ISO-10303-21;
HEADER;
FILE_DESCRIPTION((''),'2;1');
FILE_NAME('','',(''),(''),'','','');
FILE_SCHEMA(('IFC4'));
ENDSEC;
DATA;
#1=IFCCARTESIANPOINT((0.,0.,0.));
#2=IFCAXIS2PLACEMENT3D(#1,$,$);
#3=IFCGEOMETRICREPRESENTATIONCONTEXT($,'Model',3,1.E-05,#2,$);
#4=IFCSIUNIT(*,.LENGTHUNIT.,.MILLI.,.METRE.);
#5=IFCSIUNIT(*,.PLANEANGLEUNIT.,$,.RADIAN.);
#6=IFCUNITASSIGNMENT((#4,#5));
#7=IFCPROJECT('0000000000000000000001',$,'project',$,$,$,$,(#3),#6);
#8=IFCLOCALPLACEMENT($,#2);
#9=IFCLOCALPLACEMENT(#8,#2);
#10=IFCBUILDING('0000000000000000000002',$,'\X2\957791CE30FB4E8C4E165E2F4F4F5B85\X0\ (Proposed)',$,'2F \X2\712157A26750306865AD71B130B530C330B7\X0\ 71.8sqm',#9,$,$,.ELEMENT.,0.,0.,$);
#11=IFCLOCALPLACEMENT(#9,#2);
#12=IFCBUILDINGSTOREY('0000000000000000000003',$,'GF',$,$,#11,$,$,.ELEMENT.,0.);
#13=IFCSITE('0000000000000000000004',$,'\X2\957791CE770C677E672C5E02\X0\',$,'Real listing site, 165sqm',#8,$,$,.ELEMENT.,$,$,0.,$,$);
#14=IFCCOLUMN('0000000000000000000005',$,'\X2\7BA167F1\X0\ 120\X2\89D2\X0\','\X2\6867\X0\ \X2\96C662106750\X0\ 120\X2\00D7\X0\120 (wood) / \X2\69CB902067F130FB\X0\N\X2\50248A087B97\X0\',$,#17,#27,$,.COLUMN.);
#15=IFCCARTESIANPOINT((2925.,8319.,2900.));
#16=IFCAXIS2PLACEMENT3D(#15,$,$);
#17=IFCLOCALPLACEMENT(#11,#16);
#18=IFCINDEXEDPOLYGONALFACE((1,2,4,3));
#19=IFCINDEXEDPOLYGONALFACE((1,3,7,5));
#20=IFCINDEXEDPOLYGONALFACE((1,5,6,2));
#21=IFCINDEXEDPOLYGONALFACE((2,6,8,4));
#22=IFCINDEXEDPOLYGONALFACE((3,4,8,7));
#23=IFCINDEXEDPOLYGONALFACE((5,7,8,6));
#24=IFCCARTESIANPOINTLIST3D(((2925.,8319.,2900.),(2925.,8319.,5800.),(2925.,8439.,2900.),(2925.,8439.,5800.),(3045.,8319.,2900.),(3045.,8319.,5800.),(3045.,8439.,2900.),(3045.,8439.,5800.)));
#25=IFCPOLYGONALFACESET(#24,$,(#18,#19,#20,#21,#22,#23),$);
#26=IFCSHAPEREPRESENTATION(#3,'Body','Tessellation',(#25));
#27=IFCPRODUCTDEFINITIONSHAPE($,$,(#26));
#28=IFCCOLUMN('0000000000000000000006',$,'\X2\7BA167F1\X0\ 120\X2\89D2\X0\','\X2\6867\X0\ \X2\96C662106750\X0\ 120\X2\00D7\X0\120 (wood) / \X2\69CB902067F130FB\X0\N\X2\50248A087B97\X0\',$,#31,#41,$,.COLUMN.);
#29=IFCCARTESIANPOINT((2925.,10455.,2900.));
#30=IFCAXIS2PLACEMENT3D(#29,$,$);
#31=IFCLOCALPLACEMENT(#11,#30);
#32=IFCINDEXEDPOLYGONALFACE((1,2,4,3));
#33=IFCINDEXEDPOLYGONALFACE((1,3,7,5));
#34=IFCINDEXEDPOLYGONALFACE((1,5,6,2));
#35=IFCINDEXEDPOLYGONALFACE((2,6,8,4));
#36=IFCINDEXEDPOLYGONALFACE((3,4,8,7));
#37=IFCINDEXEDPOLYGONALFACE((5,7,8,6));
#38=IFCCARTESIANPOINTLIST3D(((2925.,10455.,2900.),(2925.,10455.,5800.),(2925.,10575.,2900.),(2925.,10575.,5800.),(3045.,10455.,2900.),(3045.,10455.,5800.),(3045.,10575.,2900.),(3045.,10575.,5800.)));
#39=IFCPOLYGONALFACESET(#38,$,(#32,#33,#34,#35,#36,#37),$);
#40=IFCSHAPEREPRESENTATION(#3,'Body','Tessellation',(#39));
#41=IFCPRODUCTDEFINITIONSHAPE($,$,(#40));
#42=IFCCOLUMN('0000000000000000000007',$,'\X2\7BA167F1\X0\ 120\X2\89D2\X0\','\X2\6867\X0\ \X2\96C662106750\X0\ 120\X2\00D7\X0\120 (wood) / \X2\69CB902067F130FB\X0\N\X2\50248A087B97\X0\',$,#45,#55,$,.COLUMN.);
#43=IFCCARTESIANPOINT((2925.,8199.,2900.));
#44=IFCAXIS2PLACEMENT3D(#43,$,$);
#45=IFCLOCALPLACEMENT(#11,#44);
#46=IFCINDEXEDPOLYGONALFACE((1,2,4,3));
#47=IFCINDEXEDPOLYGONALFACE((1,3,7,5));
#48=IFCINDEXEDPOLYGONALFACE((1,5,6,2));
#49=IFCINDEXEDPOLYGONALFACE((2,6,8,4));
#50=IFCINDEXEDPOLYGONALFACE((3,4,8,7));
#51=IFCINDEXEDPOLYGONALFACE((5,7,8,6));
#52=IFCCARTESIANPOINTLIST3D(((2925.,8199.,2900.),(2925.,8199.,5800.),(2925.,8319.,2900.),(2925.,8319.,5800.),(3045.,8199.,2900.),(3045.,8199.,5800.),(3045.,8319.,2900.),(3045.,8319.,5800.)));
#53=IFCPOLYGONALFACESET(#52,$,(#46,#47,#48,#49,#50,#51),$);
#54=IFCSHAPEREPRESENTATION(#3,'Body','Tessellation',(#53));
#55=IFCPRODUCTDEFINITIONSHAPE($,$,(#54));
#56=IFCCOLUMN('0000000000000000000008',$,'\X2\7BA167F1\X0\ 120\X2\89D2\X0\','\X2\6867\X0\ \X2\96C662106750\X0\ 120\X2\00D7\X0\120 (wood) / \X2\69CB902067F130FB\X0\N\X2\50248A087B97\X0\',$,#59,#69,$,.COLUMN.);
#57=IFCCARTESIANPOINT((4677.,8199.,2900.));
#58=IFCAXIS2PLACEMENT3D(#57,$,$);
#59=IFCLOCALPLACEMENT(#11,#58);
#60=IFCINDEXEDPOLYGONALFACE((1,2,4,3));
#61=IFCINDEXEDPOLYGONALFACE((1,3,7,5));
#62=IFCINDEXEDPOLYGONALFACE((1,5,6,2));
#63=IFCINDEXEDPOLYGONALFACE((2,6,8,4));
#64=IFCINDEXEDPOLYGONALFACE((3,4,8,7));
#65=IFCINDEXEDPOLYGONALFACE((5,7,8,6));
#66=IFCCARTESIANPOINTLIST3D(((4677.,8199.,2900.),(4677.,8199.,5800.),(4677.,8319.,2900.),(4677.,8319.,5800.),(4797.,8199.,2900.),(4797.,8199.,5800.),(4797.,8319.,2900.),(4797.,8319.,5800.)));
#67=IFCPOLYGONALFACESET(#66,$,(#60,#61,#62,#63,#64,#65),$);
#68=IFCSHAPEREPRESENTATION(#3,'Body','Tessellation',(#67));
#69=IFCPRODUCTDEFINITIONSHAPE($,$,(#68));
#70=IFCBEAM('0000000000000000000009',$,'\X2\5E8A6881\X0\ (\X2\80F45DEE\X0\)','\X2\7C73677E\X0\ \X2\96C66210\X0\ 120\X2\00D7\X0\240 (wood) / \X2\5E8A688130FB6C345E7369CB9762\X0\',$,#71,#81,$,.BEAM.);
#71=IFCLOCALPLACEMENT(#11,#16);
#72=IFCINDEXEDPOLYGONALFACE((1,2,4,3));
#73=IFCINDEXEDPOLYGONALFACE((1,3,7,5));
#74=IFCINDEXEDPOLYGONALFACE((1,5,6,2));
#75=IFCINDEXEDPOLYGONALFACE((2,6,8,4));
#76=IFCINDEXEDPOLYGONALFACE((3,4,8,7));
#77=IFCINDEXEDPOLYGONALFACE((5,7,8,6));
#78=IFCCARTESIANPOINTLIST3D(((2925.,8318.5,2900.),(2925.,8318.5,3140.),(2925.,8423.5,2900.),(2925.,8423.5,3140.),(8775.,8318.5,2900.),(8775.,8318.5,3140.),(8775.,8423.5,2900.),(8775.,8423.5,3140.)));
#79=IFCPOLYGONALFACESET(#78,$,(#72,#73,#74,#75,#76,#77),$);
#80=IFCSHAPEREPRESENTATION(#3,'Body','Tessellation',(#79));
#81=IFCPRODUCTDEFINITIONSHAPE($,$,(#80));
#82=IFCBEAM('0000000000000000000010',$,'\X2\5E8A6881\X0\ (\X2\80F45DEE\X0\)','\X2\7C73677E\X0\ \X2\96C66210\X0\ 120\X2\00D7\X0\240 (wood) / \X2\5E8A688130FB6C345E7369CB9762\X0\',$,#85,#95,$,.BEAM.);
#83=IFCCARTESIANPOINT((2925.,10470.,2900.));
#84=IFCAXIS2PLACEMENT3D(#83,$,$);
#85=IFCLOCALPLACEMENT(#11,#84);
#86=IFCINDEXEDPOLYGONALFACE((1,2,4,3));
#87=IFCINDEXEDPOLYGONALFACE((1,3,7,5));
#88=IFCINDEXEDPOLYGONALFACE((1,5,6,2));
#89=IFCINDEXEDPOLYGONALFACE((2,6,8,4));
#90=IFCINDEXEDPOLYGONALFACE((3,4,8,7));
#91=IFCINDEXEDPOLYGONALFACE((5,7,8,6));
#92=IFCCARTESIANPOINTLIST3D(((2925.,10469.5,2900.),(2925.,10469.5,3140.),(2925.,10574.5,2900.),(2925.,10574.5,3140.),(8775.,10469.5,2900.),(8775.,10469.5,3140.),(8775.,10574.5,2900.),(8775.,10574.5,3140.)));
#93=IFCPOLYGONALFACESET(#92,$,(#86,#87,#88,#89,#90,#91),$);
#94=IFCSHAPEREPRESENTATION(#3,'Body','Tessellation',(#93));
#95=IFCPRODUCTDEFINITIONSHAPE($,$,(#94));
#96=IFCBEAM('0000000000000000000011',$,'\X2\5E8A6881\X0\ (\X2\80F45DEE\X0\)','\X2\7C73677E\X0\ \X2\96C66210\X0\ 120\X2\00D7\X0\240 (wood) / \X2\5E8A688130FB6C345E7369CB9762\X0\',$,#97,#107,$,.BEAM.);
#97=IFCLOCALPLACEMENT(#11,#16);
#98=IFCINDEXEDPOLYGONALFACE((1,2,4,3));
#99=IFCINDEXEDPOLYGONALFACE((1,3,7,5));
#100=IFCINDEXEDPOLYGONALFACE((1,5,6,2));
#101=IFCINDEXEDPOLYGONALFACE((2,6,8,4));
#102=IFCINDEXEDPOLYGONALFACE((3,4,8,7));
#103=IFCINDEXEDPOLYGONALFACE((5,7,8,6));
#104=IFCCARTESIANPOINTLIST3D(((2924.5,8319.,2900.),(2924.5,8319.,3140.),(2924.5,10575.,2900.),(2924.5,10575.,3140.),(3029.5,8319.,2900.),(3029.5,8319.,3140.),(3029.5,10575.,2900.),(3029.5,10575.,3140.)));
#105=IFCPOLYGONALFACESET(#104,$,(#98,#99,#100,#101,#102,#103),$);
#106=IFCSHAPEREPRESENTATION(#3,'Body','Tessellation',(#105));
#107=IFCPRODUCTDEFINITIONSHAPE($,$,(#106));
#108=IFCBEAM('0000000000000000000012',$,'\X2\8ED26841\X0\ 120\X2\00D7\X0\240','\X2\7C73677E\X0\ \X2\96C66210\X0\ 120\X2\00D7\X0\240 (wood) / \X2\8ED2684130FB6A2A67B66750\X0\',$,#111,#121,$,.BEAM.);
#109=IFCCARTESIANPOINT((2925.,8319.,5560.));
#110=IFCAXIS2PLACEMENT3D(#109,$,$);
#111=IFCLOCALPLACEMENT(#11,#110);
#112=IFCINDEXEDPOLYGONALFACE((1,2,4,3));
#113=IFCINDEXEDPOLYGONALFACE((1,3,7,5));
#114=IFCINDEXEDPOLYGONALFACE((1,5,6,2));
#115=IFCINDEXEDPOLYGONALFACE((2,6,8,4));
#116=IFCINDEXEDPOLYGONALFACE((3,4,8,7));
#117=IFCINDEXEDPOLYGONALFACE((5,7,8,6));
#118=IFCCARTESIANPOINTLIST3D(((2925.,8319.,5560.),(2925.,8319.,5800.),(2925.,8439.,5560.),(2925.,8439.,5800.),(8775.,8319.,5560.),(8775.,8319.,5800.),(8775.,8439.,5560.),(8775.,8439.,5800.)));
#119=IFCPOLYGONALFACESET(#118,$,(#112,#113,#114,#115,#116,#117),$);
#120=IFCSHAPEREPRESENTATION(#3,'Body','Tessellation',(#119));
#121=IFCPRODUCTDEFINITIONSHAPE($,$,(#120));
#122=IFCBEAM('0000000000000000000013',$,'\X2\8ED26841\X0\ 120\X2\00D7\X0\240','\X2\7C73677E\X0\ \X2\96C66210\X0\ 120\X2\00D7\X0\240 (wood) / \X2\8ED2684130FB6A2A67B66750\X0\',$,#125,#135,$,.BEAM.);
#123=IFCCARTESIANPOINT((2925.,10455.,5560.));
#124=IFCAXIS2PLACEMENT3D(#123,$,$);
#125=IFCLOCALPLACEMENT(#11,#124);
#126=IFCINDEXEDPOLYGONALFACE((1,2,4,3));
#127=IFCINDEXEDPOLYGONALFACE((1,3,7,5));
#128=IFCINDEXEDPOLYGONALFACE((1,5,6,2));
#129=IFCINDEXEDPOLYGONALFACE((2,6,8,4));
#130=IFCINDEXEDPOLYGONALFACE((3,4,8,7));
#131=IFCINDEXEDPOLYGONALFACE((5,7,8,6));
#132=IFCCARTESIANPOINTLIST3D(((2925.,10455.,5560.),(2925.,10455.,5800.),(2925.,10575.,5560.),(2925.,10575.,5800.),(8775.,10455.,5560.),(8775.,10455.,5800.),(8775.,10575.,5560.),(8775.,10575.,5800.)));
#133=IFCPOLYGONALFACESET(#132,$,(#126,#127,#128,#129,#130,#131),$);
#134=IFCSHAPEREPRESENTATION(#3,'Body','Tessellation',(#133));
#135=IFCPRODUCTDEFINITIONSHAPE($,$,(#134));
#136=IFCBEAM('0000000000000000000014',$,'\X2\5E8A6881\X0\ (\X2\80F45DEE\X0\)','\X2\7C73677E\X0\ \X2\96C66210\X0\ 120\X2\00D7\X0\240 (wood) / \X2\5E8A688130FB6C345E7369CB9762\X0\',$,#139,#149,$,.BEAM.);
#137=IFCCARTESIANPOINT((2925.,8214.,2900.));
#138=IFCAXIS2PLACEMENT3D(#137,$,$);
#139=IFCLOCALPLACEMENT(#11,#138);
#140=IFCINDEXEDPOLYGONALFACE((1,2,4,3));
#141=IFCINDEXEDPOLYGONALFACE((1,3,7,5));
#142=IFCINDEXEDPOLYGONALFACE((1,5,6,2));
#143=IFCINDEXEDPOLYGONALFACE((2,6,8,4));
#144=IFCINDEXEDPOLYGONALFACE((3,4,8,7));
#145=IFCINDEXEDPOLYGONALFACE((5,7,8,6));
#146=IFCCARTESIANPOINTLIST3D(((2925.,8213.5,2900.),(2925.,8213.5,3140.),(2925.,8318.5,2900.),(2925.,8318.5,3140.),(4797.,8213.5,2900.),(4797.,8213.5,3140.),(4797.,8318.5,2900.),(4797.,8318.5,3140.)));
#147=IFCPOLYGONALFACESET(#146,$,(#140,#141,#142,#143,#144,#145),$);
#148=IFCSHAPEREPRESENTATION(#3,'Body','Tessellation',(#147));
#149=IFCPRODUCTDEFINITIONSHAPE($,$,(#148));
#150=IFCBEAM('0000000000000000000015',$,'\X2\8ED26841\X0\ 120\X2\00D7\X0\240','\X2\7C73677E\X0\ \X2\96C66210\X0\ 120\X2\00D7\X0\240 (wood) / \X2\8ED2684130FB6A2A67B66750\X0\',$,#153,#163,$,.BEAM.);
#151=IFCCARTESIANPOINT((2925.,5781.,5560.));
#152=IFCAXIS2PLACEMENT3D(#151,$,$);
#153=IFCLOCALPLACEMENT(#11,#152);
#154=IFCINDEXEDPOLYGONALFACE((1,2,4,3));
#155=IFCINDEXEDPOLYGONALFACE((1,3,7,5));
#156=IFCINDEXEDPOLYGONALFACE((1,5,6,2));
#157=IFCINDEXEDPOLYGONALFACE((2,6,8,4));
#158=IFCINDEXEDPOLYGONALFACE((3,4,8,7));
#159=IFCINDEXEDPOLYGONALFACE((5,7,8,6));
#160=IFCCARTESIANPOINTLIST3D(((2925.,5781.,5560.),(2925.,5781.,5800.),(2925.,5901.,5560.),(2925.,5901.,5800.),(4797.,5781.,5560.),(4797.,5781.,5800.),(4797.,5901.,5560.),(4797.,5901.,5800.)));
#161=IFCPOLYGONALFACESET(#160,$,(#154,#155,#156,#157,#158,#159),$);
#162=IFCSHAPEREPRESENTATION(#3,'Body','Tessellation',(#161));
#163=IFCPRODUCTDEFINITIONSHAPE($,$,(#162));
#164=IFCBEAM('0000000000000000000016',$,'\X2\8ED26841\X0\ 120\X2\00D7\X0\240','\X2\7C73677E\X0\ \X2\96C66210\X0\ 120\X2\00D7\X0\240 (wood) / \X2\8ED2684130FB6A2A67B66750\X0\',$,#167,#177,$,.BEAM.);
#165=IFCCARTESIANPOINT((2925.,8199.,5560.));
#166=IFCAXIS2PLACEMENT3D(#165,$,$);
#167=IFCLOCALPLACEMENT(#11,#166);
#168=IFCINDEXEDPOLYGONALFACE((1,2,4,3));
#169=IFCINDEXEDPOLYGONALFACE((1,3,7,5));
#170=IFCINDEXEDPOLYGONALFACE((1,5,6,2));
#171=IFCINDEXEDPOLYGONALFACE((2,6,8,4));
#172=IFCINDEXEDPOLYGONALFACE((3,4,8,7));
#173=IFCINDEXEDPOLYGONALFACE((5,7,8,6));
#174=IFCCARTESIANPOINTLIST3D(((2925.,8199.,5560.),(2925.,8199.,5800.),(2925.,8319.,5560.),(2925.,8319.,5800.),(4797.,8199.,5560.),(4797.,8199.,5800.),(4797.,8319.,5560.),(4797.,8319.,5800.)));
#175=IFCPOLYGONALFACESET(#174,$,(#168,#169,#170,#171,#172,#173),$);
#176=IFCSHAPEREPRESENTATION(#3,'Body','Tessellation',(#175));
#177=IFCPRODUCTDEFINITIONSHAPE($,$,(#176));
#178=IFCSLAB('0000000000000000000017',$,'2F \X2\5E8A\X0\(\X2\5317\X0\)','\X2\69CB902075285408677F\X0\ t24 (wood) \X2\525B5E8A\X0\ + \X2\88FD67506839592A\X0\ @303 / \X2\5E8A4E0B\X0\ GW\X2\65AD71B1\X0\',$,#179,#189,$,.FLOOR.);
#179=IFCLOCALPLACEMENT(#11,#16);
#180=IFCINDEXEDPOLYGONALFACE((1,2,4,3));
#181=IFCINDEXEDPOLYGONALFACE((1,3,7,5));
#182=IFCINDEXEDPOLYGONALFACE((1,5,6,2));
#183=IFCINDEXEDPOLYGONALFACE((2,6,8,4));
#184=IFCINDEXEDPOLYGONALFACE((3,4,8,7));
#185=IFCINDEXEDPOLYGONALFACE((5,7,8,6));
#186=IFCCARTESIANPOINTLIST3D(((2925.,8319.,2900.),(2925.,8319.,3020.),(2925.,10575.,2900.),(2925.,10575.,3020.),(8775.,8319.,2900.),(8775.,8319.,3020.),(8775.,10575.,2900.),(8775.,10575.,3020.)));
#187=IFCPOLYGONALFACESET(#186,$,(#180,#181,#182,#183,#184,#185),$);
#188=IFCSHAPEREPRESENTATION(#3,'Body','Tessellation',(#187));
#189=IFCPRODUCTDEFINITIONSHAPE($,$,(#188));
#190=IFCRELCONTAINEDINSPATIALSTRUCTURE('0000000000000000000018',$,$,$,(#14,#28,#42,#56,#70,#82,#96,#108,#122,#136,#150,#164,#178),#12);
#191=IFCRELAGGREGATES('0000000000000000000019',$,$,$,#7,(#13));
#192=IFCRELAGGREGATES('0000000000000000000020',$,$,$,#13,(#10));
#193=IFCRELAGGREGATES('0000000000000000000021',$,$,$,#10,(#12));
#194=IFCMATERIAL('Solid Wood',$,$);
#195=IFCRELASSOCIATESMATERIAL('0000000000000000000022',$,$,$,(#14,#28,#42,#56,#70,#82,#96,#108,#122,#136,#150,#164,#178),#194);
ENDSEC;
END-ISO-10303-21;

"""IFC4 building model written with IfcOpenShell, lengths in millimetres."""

from ifc_helpers import new_model, si_unit, frame, frame_2d, origin, place, context, project, spatial, rectangle, extrude, material, element, save


model = new_model("IFC4")

# Units and contexts
model_context = context("Model", 3, precision=1e-05, world=origin())
ifc_project = project(units=[si_unit("LENGTHUNIT", "METRE", prefix="MILLI"), si_unit("PLANEANGLEUNIT", "RADIAN")], contexts=[model_context])

# Site, building, storey
site_placement = place(None, origin())
site = spatial("IfcSite", under=ifc_project, at=site_placement, Name="長野県松本市", ObjectType="Real listing site, 165sqm", CompositionType="ELEMENT", RefElevation=0.0)
building_placement = place(site_placement, origin())
building = spatial("IfcBuilding", under=site, at=building_placement, Name="長野・二世帯住宅 (Proposed)", ObjectType="2F 無垢材と断熱サッシ 71.8sqm", CompositionType="ELEMENT", ElevationOfRefHeight=0.0, ElevationOfTerrain=0.0)
storey_placement = place(building_placement, origin())
storey = spatial("IfcBuildingStorey", under=building, at=storey_placement, Name="GF", CompositionType="ELEMENT", Elevation=0.0)

# Columns
ifc_material_1 = material(Name="Solid Wood")
column_1_placement = place(storey_placement, frame((2925.0, 8319.0, 2900.0)))
element("IfcColumn", 1, at=column_1_placement, inside=storey, material=ifc_material_1, Name="管柱 120角", Description="桧 集成材 120×120 (wood) / 構造柱・N値計算", PredefinedType="COLUMN", context=model_context, shape_type="SweptSolid", body=[
    extrude(rectangle(XDim=120.0, YDim=120.0, at=frame_2d((60.0, 60.0))), frame((2925.0, 8319.0, 2900.0)), (0.0, 0.0, 1.0), 2900.0),
])
column_2_placement = place(storey_placement, frame((2925.0, 10455.0, 2900.0)))
element("IfcColumn", 2, at=column_2_placement, inside=storey, material=ifc_material_1, Name="管柱 120角", Description="桧 集成材 120×120 (wood) / 構造柱・N値計算", PredefinedType="COLUMN", context=model_context, shape_type="SweptSolid", body=[
    extrude(rectangle(XDim=120.0, YDim=120.0, at=frame_2d((60.0, 60.0))), frame((2925.0, 10455.0, 2900.0)), (0.0, 0.0, 1.0), 2900.0),
])
column_3_placement = place(storey_placement, frame((2925.0, 8199.0, 2900.0)))
element("IfcColumn", 3, at=column_3_placement, inside=storey, material=ifc_material_1, Name="管柱 120角", Description="桧 集成材 120×120 (wood) / 構造柱・N値計算", PredefinedType="COLUMN", context=model_context, shape_type="SweptSolid", body=[
    extrude(rectangle(XDim=120.0, YDim=120.0, at=frame_2d((60.0, 60.0))), frame((2925.0, 8199.0, 2900.0)), (0.0, 0.0, 1.0), 2900.0),
])
column_4_placement = place(storey_placement, frame((4677.0, 8199.0, 2900.0)))
element("IfcColumn", 4, at=column_4_placement, inside=storey, material=ifc_material_1, Name="管柱 120角", Description="桧 集成材 120×120 (wood) / 構造柱・N値計算", PredefinedType="COLUMN", context=model_context, shape_type="SweptSolid", body=[
    extrude(rectangle(XDim=120.0, YDim=120.0, at=frame_2d((60.0, 60.0))), frame((4677.0, 8199.0, 2900.0)), (0.0, 0.0, 1.0), 2900.0),
])

# Beams
beam_1_placement = place(storey_placement, frame((2925.0, 8319.0, 2900.0)))
element("IfcBeam", 5, at=beam_1_placement, inside=storey, material=ifc_material_1, Name="床梁 (胴差)", Description="米松 集成 120×240 (wood) / 床梁・水平構面", PredefinedType="BEAM", context=model_context, shape_type="SweptSolid", body=[
    extrude(rectangle(XDim=5850.0, YDim=105.0, at=frame_2d((2925.0, 52.0))), frame((2925.0, 8319.0, 2900.0)), (0.0, 0.0, 1.0), 240.0),
])
beam_2_placement = place(storey_placement, frame((2925.0, 10470.0, 2900.0)))
element("IfcBeam", 6, at=beam_2_placement, inside=storey, material=ifc_material_1, Name="床梁 (胴差)", Description="米松 集成 120×240 (wood) / 床梁・水平構面", PredefinedType="BEAM", context=model_context, shape_type="SweptSolid", body=[
    extrude(rectangle(XDim=5850.0, YDim=105.0, at=frame_2d((2925.0, 52.0))), frame((2925.0, 10470.0, 2900.0)), (0.0, 0.0, 1.0), 240.0),
])
beam_3_placement = place(storey_placement, frame((2925.0, 8319.0, 2900.0)))
element("IfcBeam", 7, at=beam_3_placement, inside=storey, material=ifc_material_1, Name="床梁 (胴差)", Description="米松 集成 120×240 (wood) / 床梁・水平構面", PredefinedType="BEAM", context=model_context, shape_type="SweptSolid", body=[
    extrude(rectangle(XDim=105.0, YDim=2256.0, at=frame_2d((52.0, 1128.0))), frame((2925.0, 8319.0, 2900.0)), (0.0, 0.0, 1.0), 240.0),
])
beam_4_placement = place(storey_placement, frame((2925.0, 8319.0, 5560.0)))
element("IfcBeam", 8, at=beam_4_placement, inside=storey, material=ifc_material_1, Name="軒桁 120×240", Description="米松 集成 120×240 (wood) / 軒桁・横架材", PredefinedType="BEAM", context=model_context, shape_type="SweptSolid", body=[
    extrude(rectangle(XDim=5850.0, YDim=120.0, at=frame_2d((2925.0, 60.0))), frame((2925.0, 8319.0, 5560.0)), (0.0, 0.0, 1.0), 240.0),
])
beam_5_placement = place(storey_placement, frame((2925.0, 10455.0, 5560.0)))
element("IfcBeam", 9, at=beam_5_placement, inside=storey, material=ifc_material_1, Name="軒桁 120×240", Description="米松 集成 120×240 (wood) / 軒桁・横架材", PredefinedType="BEAM", context=model_context, shape_type="SweptSolid", body=[
    extrude(rectangle(XDim=5850.0, YDim=120.0, at=frame_2d((2925.0, 60.0))), frame((2925.0, 10455.0, 5560.0)), (0.0, 0.0, 1.0), 240.0),
])
beam_6_placement = place(storey_placement, frame((2925.0, 8214.0, 2900.0)))
element("IfcBeam", 10, at=beam_6_placement, inside=storey, material=ifc_material_1, Name="床梁 (胴差)", Description="米松 集成 120×240 (wood) / 床梁・水平構面", PredefinedType="BEAM", context=model_context, shape_type="SweptSolid", body=[
    extrude(rectangle(XDim=1872.0, YDim=105.0, at=frame_2d((936.0, 52.0))), frame((2925.0, 8214.0, 2900.0)), (0.0, 0.0, 1.0), 240.0),
])
beam_7_placement = place(storey_placement, frame((2925.0, 5781.0, 5560.0)))
element("IfcBeam", 11, at=beam_7_placement, inside=storey, material=ifc_material_1, Name="軒桁 120×240", Description="米松 集成 120×240 (wood) / 軒桁・横架材", PredefinedType="BEAM", context=model_context, shape_type="SweptSolid", body=[
    extrude(rectangle(XDim=1872.0, YDim=120.0, at=frame_2d((936.0, 60.0))), frame((2925.0, 5781.0, 5560.0)), (0.0, 0.0, 1.0), 240.0),
])
beam_8_placement = place(storey_placement, frame((2925.0, 8199.0, 5560.0)))
element("IfcBeam", 12, at=beam_8_placement, inside=storey, material=ifc_material_1, Name="軒桁 120×240", Description="米松 集成 120×240 (wood) / 軒桁・横架材", PredefinedType="BEAM", context=model_context, shape_type="SweptSolid", body=[
    extrude(rectangle(XDim=1872.0, YDim=120.0, at=frame_2d((936.0, 60.0))), frame((2925.0, 8199.0, 5560.0)), (0.0, 0.0, 1.0), 240.0),
])

# Slab
slab_placement = place(storey_placement, frame((2925.0, 8319.0, 2900.0)))
element("IfcSlab", 13, at=slab_placement, inside=storey, material=ifc_material_1, Name="2F 床(北)", Description="構造用合板 t24 (wood) 剛床 + 製材根太 @303 / 床下 GW断熱", PredefinedType="FLOOR", context=model_context, shape_type="SweptSolid", body=[
    extrude(rectangle(XDim=5850.0, YDim=2256.0, at=frame_2d((2925.0, 1128.0))), frame((2925.0, 8319.0, 2900.0)), (0.0, 0.0, 1.0), 120.0),
])

save(model, "model.ifc")
